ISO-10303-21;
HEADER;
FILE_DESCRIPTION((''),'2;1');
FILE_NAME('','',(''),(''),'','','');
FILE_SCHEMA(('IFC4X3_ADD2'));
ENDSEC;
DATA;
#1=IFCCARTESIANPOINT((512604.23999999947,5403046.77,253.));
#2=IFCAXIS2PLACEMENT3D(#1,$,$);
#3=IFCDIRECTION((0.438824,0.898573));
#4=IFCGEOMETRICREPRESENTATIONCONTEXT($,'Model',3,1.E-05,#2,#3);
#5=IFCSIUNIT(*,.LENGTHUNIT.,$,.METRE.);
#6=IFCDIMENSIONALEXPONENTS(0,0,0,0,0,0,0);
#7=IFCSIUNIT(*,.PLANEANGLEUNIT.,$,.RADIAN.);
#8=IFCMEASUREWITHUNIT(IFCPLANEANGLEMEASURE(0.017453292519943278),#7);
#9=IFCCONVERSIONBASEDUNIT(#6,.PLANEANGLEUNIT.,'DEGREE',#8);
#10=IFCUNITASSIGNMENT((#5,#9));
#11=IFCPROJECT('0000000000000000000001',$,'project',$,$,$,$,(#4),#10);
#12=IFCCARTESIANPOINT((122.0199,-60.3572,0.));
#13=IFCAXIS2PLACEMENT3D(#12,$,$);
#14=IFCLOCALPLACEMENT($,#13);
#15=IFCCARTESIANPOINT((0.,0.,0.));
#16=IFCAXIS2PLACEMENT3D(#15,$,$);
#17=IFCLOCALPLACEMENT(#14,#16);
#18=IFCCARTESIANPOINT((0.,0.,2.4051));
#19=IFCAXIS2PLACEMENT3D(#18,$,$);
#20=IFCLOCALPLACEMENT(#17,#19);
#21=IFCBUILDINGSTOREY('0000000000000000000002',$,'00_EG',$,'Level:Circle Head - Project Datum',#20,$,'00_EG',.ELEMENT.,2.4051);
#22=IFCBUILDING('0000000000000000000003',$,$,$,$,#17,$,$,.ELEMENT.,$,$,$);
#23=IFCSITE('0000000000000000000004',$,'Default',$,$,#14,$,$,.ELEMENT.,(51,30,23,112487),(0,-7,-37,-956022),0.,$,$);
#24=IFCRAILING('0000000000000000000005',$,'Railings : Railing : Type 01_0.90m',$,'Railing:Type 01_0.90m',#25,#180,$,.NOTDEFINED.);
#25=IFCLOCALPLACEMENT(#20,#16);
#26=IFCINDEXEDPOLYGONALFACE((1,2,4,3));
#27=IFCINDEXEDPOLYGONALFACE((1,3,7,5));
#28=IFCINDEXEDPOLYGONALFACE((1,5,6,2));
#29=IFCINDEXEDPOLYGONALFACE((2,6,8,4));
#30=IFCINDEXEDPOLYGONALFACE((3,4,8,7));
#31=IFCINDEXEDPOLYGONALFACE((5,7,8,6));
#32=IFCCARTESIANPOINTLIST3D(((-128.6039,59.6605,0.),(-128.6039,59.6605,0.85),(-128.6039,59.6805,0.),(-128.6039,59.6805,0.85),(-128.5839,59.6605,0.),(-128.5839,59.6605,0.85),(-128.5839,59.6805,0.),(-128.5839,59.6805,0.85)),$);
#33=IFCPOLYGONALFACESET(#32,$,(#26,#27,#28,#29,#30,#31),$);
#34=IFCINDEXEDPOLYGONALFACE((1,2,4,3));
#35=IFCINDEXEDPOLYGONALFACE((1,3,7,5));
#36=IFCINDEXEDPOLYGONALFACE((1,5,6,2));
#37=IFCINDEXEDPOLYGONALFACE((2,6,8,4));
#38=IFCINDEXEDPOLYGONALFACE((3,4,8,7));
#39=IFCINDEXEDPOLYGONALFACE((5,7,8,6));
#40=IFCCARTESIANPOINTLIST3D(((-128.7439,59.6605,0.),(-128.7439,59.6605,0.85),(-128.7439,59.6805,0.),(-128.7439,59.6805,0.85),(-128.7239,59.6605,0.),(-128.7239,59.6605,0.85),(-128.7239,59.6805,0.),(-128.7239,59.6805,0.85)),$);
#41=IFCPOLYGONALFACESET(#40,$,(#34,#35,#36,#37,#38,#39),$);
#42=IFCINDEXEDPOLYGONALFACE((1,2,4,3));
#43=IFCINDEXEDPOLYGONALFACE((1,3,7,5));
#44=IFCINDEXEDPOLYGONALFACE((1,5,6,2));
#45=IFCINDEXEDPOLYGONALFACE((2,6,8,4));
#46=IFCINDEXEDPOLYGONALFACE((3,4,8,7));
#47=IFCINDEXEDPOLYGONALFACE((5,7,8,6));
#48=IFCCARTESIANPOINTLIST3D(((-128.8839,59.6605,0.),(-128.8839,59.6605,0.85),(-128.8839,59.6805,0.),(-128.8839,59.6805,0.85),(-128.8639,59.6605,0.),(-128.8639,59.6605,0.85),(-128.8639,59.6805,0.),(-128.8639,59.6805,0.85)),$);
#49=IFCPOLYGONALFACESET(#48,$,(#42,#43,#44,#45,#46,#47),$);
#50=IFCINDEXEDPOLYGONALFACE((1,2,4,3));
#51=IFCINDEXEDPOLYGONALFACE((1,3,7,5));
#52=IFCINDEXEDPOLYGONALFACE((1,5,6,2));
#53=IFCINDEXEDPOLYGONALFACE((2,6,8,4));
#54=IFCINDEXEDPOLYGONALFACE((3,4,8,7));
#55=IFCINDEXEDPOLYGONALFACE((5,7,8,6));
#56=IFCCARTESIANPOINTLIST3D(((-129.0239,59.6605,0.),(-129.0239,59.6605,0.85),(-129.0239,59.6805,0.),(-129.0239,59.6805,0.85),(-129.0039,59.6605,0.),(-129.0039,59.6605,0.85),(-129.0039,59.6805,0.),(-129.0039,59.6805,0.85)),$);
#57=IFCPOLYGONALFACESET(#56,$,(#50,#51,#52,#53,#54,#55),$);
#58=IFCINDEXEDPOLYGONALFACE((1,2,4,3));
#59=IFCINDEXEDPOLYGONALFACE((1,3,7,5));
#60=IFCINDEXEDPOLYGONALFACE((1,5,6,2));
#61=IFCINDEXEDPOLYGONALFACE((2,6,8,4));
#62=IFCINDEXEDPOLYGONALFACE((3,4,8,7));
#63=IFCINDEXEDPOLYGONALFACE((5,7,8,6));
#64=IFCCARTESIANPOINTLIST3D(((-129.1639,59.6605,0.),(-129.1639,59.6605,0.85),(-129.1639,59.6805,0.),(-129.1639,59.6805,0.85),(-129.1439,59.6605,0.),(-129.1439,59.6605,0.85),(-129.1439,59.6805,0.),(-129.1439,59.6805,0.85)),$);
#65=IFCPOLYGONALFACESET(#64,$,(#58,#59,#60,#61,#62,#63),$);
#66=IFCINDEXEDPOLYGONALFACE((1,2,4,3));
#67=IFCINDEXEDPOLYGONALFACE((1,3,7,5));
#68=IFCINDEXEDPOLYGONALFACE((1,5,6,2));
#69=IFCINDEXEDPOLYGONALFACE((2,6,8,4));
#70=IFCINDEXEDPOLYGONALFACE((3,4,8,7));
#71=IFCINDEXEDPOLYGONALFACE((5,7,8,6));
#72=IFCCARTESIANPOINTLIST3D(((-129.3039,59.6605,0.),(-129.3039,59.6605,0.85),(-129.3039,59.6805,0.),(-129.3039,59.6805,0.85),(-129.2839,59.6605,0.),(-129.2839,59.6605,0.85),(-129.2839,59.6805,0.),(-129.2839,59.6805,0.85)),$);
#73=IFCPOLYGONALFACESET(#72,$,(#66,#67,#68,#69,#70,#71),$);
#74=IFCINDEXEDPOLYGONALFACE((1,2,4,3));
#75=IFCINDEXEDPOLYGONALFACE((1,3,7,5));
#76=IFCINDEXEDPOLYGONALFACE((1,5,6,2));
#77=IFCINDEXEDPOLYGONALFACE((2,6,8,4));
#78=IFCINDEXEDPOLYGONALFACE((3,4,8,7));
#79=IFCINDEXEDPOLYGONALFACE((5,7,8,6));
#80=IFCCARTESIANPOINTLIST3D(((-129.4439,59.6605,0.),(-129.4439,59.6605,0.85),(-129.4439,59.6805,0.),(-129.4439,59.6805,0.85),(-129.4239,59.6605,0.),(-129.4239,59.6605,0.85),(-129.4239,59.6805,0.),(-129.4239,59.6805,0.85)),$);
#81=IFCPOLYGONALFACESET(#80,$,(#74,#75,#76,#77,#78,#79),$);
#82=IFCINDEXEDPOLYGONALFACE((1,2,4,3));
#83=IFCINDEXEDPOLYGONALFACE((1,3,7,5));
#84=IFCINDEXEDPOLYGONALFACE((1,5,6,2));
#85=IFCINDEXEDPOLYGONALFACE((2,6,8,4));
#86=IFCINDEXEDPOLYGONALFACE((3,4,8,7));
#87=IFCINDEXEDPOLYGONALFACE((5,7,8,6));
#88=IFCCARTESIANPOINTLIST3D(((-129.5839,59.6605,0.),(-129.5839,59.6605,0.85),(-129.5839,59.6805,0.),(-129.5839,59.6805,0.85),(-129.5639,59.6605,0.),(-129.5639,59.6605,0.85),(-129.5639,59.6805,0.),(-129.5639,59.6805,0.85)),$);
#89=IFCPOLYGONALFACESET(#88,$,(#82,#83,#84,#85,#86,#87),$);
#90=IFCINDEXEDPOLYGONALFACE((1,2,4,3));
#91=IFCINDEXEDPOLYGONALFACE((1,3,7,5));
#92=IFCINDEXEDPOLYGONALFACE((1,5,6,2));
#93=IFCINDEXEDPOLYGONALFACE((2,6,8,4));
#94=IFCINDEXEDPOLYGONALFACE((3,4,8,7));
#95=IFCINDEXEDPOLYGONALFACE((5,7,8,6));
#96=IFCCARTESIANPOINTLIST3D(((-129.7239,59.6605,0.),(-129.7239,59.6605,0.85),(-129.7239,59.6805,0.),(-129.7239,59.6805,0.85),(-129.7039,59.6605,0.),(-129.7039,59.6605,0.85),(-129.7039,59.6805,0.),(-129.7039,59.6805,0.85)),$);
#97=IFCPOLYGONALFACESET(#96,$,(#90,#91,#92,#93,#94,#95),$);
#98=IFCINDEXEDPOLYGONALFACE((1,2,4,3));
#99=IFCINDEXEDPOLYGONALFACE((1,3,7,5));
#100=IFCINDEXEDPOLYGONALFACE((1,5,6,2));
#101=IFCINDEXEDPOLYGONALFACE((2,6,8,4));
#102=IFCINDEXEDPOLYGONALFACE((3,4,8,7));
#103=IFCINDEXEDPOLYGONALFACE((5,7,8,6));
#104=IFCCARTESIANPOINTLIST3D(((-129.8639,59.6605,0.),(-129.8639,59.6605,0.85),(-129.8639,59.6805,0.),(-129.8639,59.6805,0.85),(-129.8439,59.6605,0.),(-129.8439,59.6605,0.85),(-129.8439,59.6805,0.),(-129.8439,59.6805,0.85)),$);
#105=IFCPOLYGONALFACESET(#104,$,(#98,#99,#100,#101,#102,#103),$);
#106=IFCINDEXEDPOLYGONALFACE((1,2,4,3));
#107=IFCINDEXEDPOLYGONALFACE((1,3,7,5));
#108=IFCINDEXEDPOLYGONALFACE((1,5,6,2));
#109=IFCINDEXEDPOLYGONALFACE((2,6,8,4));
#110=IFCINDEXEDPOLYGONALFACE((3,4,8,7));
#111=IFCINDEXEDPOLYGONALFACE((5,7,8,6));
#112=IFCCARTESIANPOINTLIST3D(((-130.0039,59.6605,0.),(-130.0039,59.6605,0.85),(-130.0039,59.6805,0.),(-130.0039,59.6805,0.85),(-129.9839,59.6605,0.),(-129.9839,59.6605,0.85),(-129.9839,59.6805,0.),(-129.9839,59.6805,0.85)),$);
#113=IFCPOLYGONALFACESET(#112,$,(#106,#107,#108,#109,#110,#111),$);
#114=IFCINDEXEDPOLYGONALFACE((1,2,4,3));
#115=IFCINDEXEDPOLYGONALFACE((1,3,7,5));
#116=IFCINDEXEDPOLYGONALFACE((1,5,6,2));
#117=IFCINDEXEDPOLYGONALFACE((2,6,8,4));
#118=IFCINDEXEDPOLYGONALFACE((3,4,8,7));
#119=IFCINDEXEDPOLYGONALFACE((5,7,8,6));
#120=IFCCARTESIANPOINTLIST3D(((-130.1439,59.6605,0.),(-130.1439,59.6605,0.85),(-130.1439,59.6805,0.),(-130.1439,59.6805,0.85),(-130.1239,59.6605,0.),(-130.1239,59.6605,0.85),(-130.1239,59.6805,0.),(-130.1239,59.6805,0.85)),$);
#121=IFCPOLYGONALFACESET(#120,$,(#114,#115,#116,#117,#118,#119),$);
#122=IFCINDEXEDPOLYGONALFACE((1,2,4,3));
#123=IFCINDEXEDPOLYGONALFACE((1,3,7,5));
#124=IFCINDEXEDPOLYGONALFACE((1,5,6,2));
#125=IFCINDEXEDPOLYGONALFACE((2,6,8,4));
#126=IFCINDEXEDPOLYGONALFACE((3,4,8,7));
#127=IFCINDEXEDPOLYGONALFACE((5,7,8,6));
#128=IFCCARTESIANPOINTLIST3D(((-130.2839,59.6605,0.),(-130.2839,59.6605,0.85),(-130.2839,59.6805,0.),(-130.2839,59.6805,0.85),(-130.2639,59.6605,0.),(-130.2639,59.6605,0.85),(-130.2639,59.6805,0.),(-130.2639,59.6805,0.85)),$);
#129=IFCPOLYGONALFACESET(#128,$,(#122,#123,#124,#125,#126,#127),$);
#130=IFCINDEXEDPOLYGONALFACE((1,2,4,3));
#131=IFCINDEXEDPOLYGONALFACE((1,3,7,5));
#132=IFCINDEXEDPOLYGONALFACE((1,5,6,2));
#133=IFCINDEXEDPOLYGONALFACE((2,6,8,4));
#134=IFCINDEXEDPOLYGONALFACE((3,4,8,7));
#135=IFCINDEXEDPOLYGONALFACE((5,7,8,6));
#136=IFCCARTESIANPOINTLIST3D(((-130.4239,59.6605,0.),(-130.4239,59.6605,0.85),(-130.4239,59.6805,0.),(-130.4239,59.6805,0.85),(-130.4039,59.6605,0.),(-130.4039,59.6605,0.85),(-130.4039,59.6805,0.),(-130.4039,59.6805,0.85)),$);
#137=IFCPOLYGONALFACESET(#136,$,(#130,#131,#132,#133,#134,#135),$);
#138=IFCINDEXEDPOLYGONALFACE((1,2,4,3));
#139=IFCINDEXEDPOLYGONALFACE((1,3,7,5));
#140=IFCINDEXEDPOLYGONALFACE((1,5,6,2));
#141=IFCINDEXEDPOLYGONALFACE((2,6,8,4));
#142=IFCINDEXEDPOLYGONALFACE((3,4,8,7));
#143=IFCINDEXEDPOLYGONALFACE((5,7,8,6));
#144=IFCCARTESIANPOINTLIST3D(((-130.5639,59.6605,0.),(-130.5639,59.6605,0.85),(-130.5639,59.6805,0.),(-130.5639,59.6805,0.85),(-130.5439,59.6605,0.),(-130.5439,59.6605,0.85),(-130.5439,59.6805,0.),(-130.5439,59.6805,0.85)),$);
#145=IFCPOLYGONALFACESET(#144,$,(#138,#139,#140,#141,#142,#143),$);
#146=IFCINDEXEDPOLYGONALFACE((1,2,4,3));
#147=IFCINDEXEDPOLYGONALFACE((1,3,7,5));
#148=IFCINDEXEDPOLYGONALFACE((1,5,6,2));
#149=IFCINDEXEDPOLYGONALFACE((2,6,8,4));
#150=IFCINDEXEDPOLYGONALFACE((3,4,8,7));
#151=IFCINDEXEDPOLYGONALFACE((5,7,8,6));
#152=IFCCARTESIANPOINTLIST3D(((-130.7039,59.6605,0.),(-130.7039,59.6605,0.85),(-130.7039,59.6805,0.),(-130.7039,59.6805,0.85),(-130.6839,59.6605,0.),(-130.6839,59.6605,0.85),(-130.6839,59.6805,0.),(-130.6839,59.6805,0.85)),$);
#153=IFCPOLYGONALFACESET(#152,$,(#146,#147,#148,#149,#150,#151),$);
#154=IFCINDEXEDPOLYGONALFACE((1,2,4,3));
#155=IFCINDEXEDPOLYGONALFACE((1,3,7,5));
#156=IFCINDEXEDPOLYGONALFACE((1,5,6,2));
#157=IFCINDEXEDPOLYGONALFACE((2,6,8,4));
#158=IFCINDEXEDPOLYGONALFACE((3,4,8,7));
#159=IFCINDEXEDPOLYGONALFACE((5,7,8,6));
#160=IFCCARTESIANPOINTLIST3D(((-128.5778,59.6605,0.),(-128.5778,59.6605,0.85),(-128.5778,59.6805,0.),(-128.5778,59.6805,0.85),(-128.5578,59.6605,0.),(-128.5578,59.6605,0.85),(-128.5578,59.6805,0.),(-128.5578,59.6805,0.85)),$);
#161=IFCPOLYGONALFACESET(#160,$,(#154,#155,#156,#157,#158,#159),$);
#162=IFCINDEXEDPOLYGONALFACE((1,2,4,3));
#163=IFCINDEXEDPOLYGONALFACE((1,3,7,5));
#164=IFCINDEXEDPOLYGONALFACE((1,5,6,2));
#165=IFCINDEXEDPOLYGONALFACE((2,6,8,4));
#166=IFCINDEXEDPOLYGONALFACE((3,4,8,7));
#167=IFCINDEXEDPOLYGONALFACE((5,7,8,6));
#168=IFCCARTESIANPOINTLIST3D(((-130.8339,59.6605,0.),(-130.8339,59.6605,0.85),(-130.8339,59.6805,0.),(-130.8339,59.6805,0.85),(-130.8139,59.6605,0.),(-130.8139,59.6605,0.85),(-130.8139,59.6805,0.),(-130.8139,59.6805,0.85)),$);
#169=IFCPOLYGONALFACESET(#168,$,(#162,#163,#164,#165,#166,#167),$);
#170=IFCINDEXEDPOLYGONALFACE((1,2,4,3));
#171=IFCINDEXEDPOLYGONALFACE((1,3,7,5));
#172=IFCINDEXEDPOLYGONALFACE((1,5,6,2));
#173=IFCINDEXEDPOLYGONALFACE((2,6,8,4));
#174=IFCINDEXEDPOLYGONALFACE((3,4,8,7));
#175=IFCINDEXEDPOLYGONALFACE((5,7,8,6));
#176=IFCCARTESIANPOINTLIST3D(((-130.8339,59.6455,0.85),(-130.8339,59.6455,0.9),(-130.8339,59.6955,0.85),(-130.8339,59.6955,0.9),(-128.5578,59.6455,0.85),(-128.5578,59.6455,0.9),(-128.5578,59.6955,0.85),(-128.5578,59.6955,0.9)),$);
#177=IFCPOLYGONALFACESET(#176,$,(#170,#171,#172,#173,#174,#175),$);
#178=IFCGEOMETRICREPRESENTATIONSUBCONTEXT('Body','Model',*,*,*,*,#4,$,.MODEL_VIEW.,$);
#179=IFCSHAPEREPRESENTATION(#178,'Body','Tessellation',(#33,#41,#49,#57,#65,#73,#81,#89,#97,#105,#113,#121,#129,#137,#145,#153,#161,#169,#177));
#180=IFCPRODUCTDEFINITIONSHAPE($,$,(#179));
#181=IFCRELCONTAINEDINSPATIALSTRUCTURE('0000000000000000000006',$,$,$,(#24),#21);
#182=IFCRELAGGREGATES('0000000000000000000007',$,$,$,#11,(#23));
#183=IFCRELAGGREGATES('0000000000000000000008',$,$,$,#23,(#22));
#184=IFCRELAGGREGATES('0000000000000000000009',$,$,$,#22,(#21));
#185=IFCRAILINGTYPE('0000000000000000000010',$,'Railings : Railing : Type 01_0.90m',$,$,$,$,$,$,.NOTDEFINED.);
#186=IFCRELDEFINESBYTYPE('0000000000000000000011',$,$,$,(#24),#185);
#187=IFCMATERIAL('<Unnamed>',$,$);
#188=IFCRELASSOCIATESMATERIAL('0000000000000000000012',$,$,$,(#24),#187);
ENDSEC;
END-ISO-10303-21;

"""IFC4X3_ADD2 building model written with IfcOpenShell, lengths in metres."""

from ifc_helpers import new_model, entity, si_unit, converted_unit, direction, frame, origin, origin_2d_with_axis, place, context, subcontext, project, spatial, rectangle, extrude, material, type_object, element, save


model = new_model("IFC4X3_ADD2")

# Units and contexts
model_context = context("Model", 3, precision=1e-05, world=frame((512604.23999999947, 5403046.77, 253.0)), true_north=direction((0.438824, 0.898573)))
body_context = subcontext(model_context, "Body", "Model", "MODEL_VIEW")
ifc_project = project(units=[si_unit("LENGTHUNIT", "METRE"), converted_unit("PLANEANGLEUNIT", "DEGREE", entity("IfcPlaneAngleMeasure", 0.017453292519943278), si_unit("PLANEANGLEUNIT", "RADIAN"), dimensions=[0, 0, 0, 0, 0, 0, 0])], contexts=[model_context])

# Site, building, storey
site_placement = place(None, frame((122.0199, -60.3572, 0.0)))
site = spatial("IfcSite", under=ifc_project, at=site_placement, Name="Default", CompositionType="ELEMENT", RefLatitude=(51, 30, 23, 112487), RefLongitude=(0, -7, -37, -956022), RefElevation=0.0)
building_placement = place(site_placement, origin())
building = spatial("IfcBuilding", under=site, at=building_placement, CompositionType="ELEMENT")
storey_placement = place(building_placement, frame((0.0, 0.0, 2.4051)))
storey = spatial("IfcBuildingStorey", under=building, at=storey_placement, Name="00_EG", ObjectType="Level:Circle Head - Project Datum", LongName="00_EG", CompositionType="ELEMENT", Elevation=2.4051)

# Railing
ifc_material_1 = material(Name="<Unnamed>")
railing_type = type_object("IfcRailingType", Name="Railings : Railing : Type 01_0.90m", PredefinedType="NOTDEFINED")
railing_1_placement = place(storey_placement, frame((-130.8339, 59.6455, 0.0)))
element("IfcRailing", 1, at=railing_1_placement, inside=storey, type_object=railing_type, material=ifc_material_1, Name="Railings : Railing : Type 01_0.90m", ObjectType="Railing:Type 01_0.90m", PredefinedType="NOTDEFINED", context=body_context, shape_type="SweptSolid", body=[
    extrude(rectangle(XDim=0.02, YDim=0.02, at=origin_2d_with_axis()), frame((2.24, 0.025, 0.0)), (0.0, 0.0, 1.0), 0.85),
    extrude(rectangle(XDim=0.02, YDim=0.02, at=origin_2d_with_axis()), frame((2.1, 0.025, 0.0)), (0.0, 0.0, 1.0), 0.85),
    extrude(rectangle(XDim=0.02, YDim=0.02, at=origin_2d_with_axis()), frame((1.96, 0.025, 0.0)), (0.0, 0.0, 1.0), 0.85),
    extrude(rectangle(XDim=0.02, YDim=0.02, at=origin_2d_with_axis()), frame((1.82, 0.025, 0.0)), (0.0, 0.0, 1.0), 0.85),
    extrude(rectangle(XDim=0.02, YDim=0.02, at=origin_2d_with_axis()), frame((1.68, 0.025, 0.0)), (0.0, 0.0, 1.0), 0.85),
    extrude(rectangle(XDim=0.02, YDim=0.02, at=origin_2d_with_axis()), frame((1.54, 0.025, 0.0)), (0.0, 0.0, 1.0), 0.85),
    extrude(rectangle(XDim=0.02, YDim=0.02, at=origin_2d_with_axis()), frame((1.4, 0.025, 0.0)), (0.0, 0.0, 1.0), 0.85),
    extrude(rectangle(XDim=0.02, YDim=0.02, at=origin_2d_with_axis()), frame((1.26, 0.025, 0.0)), (0.0, 0.0, 1.0), 0.85),
    extrude(rectangle(XDim=0.02, YDim=0.02, at=origin_2d_with_axis()), frame((1.12, 0.025, 0.0)), (0.0, 0.0, 1.0), 0.85),
    extrude(rectangle(XDim=0.02, YDim=0.02, at=origin_2d_with_axis()), frame((0.98, 0.025, 0.0)), (0.0, 0.0, 1.0), 0.85),
    extrude(rectangle(XDim=0.02, YDim=0.02, at=origin_2d_with_axis()), frame((0.84, 0.025, 0.0)), (0.0, 0.0, 1.0), 0.85),
    extrude(rectangle(XDim=0.02, YDim=0.02, at=origin_2d_with_axis()), frame((0.7, 0.025, 0.0)), (0.0, 0.0, 1.0), 0.85),
    extrude(rectangle(XDim=0.02, YDim=0.02, at=origin_2d_with_axis()), frame((0.56, 0.025, 0.0)), (0.0, 0.0, 1.0), 0.85),
    extrude(rectangle(XDim=0.02, YDim=0.02, at=origin_2d_with_axis()), frame((0.42, 0.025, 0.0)), (0.0, 0.0, 1.0), 0.85),
    extrude(rectangle(XDim=0.02, YDim=0.02, at=origin_2d_with_axis()), frame((0.28, 0.025, 0.0)), (0.0, 0.0, 1.0), 0.85),
    extrude(rectangle(XDim=0.02, YDim=0.02, at=origin_2d_with_axis()), frame((0.14, 0.025, 0.0)), (0.0, 0.0, 1.0), 0.85),
    extrude(rectangle(XDim=0.02, YDim=0.02, at=origin_2d_with_axis()), frame((2.2661, 0.025, 0.0)), (0.0, 0.0, 1.0), 0.85),
    extrude(rectangle(XDim=0.02, YDim=0.02, at=origin_2d_with_axis()), frame((0.01, 0.025, 0.0)), (0.0, 0.0, 1.0), 0.85),
    extrude(rectangle(XDim=2.2761, YDim=0.05, at=origin_2d_with_axis()), frame((1.1381, 0.025, 0.85)), (0.0, 0.0, 1.0), 0.05),
])

save(model, "model.ifc")
